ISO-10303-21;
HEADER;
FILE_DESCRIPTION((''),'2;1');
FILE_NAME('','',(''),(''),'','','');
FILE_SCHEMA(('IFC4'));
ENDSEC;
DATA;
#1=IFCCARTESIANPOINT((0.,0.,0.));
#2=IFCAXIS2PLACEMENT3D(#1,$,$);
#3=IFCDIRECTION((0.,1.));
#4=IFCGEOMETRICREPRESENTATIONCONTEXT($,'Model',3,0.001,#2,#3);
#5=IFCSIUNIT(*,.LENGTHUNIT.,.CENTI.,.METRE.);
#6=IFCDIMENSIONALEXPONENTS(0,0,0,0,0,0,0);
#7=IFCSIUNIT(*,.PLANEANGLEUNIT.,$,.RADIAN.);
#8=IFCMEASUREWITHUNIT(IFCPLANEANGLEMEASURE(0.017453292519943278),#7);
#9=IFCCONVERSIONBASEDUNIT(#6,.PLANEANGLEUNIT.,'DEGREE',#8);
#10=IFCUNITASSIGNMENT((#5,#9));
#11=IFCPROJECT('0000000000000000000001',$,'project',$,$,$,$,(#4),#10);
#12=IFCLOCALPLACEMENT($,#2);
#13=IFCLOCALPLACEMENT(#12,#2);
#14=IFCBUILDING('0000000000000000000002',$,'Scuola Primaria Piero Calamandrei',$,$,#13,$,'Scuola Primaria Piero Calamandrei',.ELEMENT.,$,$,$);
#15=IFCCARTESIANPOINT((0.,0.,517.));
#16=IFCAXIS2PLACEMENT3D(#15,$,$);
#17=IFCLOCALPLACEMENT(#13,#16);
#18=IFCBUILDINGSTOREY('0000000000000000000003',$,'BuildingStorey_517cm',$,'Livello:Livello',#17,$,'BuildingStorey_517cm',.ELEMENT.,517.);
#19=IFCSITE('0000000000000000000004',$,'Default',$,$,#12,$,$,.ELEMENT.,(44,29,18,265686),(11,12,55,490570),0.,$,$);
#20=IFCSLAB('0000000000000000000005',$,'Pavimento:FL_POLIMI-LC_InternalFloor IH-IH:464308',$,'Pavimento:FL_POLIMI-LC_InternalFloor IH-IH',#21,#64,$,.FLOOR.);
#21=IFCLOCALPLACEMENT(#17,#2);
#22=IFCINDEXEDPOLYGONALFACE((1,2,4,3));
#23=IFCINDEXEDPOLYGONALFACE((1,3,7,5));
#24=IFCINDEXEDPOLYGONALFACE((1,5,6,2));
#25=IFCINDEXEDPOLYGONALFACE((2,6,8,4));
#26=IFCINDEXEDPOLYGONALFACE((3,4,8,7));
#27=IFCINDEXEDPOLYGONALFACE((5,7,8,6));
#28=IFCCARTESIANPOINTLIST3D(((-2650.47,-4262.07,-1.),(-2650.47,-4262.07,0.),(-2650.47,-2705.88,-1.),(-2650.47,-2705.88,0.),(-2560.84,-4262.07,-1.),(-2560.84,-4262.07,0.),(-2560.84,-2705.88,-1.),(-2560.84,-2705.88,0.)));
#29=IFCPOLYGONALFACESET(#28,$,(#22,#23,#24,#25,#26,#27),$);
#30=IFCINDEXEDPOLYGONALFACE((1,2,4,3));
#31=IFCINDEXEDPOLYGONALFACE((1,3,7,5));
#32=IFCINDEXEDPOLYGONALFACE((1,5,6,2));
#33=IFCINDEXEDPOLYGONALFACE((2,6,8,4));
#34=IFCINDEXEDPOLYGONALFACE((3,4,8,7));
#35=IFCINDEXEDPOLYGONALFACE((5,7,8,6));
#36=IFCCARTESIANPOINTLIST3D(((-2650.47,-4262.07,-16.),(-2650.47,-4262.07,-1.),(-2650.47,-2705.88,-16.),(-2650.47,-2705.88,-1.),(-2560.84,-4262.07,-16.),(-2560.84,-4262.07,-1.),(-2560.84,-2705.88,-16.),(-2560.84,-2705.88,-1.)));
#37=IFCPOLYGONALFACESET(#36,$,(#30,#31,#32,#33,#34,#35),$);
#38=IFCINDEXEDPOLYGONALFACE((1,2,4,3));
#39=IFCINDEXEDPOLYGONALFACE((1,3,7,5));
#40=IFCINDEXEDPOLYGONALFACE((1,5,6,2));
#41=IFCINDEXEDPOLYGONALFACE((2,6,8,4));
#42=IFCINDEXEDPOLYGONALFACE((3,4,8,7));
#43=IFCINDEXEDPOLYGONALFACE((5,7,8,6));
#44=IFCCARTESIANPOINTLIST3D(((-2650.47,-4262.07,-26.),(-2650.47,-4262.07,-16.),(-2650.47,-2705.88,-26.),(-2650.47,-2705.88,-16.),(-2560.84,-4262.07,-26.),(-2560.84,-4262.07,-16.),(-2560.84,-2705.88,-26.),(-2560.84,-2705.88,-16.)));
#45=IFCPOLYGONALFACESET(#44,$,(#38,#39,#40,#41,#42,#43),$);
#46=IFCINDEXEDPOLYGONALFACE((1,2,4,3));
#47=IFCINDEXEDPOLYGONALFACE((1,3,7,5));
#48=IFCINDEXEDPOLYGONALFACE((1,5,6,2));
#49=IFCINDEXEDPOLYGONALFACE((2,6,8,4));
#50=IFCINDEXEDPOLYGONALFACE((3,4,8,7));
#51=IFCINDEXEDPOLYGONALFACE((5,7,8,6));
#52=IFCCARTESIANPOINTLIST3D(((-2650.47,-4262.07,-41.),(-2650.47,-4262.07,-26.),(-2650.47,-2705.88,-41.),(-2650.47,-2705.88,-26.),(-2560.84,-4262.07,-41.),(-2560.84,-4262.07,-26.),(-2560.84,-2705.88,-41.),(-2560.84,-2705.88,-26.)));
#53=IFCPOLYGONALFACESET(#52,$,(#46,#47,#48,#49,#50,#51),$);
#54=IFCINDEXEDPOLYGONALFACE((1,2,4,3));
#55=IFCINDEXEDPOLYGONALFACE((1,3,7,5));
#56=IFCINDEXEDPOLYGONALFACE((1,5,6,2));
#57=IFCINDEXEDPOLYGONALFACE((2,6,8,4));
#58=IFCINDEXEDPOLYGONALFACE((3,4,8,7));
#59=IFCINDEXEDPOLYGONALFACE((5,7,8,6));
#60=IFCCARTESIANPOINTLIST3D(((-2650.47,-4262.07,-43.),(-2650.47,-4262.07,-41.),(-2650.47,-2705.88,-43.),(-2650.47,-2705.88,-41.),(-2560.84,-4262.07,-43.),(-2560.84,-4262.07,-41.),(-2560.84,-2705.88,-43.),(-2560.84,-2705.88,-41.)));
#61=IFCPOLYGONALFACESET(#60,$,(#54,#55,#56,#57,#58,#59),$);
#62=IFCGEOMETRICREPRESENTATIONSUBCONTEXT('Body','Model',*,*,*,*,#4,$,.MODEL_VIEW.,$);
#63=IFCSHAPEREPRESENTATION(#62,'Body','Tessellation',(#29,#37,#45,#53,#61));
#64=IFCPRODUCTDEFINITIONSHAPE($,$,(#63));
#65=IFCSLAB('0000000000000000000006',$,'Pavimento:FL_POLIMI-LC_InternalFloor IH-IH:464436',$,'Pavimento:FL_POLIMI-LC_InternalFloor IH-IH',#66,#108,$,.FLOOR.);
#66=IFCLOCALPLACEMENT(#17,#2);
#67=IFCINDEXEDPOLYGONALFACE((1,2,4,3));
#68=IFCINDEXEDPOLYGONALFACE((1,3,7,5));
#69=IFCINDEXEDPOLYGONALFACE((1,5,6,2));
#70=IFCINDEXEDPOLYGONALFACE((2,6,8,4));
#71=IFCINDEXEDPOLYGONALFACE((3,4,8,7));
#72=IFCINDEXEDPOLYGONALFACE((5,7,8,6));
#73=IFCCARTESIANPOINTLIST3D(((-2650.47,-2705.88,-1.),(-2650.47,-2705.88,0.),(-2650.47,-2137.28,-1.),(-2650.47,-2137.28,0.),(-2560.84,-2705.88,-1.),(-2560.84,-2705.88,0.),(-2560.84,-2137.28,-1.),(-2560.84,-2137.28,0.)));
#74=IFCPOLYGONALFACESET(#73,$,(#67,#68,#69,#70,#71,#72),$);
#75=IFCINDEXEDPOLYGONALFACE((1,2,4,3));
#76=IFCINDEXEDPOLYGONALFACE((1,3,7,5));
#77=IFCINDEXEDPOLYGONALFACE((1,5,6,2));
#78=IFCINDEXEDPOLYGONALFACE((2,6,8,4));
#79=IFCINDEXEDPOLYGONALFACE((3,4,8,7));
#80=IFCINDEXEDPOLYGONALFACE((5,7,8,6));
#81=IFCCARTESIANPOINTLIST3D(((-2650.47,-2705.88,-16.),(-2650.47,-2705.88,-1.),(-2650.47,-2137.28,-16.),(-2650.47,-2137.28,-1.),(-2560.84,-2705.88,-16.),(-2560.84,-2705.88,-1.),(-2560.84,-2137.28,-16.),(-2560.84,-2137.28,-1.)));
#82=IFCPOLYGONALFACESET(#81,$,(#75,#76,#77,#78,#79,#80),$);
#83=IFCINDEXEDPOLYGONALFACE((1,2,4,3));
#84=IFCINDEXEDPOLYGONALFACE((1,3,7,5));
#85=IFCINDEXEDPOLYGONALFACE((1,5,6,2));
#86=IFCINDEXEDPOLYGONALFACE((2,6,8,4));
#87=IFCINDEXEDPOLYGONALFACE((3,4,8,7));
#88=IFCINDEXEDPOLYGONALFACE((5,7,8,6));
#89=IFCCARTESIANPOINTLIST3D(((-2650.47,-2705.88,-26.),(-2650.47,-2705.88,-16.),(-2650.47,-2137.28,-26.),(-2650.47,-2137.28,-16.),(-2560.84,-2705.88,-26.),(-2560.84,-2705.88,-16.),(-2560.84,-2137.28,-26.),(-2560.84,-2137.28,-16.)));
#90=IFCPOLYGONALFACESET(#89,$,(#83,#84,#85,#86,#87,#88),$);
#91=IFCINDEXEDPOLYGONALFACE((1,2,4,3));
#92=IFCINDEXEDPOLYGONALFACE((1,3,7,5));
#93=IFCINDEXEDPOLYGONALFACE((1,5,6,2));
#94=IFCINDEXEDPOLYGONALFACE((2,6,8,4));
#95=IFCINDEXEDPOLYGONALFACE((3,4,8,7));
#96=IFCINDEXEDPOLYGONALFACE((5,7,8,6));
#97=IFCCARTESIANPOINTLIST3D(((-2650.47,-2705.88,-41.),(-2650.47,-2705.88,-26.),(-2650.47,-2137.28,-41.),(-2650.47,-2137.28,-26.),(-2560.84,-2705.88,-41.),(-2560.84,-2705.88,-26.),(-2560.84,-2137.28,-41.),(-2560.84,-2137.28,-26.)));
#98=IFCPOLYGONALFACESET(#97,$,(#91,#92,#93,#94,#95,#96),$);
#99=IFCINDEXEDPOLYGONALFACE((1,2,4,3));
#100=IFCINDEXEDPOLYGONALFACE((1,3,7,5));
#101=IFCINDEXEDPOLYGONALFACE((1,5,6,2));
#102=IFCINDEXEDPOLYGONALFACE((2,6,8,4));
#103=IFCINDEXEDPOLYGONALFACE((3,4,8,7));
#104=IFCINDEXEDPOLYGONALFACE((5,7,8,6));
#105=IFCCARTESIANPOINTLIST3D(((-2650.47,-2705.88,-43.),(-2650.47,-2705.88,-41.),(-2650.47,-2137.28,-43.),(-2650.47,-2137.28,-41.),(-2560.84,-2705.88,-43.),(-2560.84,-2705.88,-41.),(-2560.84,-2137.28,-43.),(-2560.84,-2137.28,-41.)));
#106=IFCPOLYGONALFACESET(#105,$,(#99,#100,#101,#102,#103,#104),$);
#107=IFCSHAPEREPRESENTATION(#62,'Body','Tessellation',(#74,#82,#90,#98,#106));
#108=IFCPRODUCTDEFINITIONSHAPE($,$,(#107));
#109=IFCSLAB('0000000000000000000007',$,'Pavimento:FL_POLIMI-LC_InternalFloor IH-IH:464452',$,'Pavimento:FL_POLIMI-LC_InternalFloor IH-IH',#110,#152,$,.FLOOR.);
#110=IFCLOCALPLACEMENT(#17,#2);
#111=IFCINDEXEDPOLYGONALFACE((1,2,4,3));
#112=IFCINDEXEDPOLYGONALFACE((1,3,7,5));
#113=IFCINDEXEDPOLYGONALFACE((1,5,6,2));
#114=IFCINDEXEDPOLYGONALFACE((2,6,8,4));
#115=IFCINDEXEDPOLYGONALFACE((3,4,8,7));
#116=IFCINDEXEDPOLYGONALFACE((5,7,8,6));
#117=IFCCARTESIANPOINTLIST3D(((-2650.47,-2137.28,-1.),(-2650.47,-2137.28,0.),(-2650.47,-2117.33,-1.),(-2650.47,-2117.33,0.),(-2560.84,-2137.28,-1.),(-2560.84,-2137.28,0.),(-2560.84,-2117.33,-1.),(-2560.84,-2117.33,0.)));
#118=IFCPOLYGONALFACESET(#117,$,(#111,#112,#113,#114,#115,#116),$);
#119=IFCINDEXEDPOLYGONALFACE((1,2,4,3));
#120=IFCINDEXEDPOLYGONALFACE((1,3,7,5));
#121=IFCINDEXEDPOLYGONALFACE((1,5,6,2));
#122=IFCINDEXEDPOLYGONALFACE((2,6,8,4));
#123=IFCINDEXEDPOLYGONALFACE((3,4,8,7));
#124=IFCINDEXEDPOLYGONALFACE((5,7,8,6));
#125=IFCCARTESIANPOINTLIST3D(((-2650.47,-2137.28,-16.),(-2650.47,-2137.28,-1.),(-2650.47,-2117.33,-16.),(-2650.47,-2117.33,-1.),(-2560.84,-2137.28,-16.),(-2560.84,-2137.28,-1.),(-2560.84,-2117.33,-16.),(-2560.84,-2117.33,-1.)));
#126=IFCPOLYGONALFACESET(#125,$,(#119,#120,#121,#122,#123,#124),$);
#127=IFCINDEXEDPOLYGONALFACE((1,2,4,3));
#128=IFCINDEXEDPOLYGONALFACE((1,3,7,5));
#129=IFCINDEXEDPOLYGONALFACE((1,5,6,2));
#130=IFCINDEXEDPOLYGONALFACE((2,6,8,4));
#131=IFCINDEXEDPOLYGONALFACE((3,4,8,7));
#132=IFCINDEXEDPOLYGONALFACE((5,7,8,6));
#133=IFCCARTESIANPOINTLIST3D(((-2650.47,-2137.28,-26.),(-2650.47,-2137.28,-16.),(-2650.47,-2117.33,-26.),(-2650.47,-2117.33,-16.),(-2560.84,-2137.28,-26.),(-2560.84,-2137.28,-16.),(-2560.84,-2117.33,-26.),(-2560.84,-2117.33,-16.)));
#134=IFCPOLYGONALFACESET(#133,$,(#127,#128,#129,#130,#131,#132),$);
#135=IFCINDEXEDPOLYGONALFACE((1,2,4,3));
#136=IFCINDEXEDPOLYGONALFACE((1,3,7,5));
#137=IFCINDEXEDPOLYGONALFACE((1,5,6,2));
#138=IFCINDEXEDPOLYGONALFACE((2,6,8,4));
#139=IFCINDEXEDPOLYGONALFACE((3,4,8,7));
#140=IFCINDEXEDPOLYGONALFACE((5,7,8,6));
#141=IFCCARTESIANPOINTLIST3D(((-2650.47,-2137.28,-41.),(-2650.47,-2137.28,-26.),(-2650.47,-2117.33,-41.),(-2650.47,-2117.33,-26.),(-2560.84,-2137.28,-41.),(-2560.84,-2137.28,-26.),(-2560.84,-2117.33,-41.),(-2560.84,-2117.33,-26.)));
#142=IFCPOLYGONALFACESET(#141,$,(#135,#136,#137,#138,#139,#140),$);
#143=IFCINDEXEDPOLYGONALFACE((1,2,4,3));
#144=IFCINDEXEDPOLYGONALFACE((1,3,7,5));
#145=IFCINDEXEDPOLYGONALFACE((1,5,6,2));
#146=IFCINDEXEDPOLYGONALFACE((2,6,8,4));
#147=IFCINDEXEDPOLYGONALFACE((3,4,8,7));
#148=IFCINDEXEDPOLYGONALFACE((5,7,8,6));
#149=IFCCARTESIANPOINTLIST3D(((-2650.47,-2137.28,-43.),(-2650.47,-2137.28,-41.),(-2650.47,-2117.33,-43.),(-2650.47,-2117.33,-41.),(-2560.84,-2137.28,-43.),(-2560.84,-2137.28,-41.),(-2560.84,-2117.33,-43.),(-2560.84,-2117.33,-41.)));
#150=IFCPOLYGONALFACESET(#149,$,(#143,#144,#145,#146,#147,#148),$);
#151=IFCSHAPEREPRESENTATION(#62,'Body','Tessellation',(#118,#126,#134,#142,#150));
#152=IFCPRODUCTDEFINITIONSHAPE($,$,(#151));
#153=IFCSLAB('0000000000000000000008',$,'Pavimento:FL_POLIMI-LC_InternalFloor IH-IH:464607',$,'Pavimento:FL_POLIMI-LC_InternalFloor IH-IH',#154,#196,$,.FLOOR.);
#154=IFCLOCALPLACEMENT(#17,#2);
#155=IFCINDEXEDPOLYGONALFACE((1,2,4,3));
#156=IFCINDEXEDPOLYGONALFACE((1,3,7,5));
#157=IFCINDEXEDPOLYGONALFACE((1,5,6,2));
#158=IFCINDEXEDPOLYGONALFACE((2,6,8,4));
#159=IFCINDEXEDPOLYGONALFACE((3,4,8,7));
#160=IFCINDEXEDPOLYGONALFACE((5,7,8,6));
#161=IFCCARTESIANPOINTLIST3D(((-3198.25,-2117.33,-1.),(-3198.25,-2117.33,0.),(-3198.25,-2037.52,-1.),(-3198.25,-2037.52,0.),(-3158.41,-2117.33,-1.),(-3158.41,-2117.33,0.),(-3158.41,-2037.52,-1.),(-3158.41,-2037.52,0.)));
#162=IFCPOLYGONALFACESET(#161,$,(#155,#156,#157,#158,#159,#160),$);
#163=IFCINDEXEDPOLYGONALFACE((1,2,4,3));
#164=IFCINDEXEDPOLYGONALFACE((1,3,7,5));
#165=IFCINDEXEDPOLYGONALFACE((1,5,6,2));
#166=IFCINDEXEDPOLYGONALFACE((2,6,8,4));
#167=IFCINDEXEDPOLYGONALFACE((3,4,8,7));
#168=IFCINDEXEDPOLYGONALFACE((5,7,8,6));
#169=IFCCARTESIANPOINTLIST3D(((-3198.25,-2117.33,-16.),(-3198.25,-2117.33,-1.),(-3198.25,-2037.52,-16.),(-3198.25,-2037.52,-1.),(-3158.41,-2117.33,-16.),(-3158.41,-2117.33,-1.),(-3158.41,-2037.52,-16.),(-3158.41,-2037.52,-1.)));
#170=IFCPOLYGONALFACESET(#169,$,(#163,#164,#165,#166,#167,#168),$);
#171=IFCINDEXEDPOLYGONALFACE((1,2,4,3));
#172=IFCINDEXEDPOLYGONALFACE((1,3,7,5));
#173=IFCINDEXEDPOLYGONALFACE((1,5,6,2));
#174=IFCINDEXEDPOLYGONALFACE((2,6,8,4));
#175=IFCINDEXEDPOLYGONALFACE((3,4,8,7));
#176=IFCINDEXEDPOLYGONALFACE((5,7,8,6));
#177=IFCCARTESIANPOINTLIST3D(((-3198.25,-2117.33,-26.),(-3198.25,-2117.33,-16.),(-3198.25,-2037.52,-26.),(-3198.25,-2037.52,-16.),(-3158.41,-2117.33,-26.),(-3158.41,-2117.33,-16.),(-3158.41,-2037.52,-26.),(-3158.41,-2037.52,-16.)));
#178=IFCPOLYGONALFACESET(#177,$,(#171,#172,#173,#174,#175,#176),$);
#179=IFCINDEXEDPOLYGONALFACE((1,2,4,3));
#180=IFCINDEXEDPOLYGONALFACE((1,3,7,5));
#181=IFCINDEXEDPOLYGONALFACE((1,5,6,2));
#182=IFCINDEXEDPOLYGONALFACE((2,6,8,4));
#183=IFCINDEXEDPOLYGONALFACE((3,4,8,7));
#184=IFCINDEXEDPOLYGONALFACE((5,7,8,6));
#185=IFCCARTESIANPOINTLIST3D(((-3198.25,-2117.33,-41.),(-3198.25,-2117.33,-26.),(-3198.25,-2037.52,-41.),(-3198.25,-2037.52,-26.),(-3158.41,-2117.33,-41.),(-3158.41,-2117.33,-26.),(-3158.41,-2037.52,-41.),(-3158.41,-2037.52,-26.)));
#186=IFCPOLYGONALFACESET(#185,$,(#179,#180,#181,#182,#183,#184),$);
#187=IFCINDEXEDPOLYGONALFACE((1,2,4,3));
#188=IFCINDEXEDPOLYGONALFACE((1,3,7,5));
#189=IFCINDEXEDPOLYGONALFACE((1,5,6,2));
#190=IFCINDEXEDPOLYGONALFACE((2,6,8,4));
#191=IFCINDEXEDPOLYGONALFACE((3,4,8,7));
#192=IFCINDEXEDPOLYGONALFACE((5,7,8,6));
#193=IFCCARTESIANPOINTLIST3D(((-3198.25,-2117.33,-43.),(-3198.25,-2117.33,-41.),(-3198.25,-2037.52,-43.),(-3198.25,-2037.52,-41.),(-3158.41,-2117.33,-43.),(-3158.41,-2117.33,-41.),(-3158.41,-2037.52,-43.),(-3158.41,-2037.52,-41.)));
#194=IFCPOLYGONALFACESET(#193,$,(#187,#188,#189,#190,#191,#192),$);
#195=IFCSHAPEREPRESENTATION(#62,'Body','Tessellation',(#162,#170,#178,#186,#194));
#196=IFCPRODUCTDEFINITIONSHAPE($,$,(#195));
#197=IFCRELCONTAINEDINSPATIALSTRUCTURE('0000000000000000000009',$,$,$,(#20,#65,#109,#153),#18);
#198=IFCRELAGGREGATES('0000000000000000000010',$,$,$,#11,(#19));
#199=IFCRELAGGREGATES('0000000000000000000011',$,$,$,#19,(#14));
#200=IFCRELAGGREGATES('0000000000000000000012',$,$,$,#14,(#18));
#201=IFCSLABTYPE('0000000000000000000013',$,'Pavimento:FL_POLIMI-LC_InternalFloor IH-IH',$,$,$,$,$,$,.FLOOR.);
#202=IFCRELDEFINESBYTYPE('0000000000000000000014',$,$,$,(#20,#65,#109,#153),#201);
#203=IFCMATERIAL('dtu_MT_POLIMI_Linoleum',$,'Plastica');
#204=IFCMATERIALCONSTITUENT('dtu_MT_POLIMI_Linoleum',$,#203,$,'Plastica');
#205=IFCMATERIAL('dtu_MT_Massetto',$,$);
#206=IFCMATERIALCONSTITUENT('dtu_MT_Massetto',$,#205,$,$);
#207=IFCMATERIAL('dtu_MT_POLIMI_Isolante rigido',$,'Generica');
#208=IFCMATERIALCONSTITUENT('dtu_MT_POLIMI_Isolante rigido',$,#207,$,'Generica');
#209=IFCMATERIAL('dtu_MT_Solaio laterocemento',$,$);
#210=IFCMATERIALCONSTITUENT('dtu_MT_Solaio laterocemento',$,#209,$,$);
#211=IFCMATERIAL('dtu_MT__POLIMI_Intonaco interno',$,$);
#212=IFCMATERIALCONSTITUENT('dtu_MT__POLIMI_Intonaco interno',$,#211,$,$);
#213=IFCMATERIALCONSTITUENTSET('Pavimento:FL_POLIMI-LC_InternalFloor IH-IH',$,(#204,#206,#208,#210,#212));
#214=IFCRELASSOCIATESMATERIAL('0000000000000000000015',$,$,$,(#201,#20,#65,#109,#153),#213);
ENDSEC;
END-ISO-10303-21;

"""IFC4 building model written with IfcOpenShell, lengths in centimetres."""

from ifc_helpers import new_model, entity, si_unit, converted_unit, direction, frame, origin, place, context, subcontext, project, spatial, indexed_curve, outline, extrude, material, constituent, constituent_set, type_object, element, save


model = new_model("IFC4")

# Units and contexts
model_context = context("Model", 3, precision=0.001, world=origin(), true_north=direction((0.0, 1.0)))
body_context = subcontext(model_context, "Body", "Model", "MODEL_VIEW")
ifc_project = project(units=[si_unit("LENGTHUNIT", "METRE", prefix="CENTI"), converted_unit("PLANEANGLEUNIT", "DEGREE", entity("IfcPlaneAngleMeasure", 0.017453292519943278), si_unit("PLANEANGLEUNIT", "RADIAN"), dimensions=[0, 0, 0, 0, 0, 0, 0])], contexts=[model_context])

# Site, building, storey
site_placement = place(None, origin())
site = spatial("IfcSite", under=ifc_project, at=site_placement, Name="Default", CompositionType="ELEMENT", RefLatitude=(44, 29, 18, 265686), RefLongitude=(11, 12, 55, 490570), RefElevation=0.0)
building_placement = place(site_placement, origin())
building = spatial("IfcBuilding", under=site, at=building_placement, Name="Scuola Primaria Piero Calamandrei", LongName="Scuola Primaria Piero Calamandrei", CompositionType="ELEMENT")
storey_placement = place(building_placement, frame((0.0, 0.0, 517.0)))
storey = spatial("IfcBuildingStorey", under=building, at=storey_placement, Name="BuildingStorey_517cm", ObjectType="Livello:Livello", LongName="BuildingStorey_517cm", CompositionType="ELEMENT", Elevation=517.0)

# Slabs
ifc_material_1 = material(Name="dtu_MT_POLIMI_Linoleum", Category="Plastica")
ifc_material_2 = material(Name="dtu_MT_Massetto")
ifc_material_3 = material(Name="dtu_MT_POLIMI_Isolante rigido", Category="Generica")
ifc_material_4 = material(Name="dtu_MT_Solaio laterocemento")
ifc_material_5 = material(Name="dtu_MT__POLIMI_Intonaco interno")
ifc_constituent_1 = constituent(ifc_material_1, Name="dtu_MT_POLIMI_Linoleum", Category="Plastica")
ifc_constituent_2 = constituent(ifc_material_2, Name="dtu_MT_Massetto")
ifc_constituent_3 = constituent(ifc_material_3, Name="dtu_MT_POLIMI_Isolante rigido", Category="Generica")
ifc_constituent_4 = constituent(ifc_material_4, Name="dtu_MT_Solaio laterocemento")
ifc_constituent_5 = constituent(ifc_material_5, Name="dtu_MT__POLIMI_Intonaco interno")
ifc_constituent_set_1 = constituent_set(constituents=[ifc_constituent_1, ifc_constituent_2, ifc_constituent_3, ifc_constituent_4, ifc_constituent_5], Name="Pavimento:FL_POLIMI-LC_InternalFloor IH-IH")
slab_type_1 = type_object("IfcSlabType", Name="Pavimento:FL_POLIMI-LC_InternalFloor IH-IH", PredefinedType="FLOOR", material=ifc_constituent_set_1)
slab_1_placement = place(storey_placement, origin())
element("IfcSlab", 1, at=slab_1_placement, inside=storey, type_object=slab_type_1, material=ifc_constituent_set_1, Name="Pavimento:FL_POLIMI-LC_InternalFloor IH-IH:464308", ObjectType="Pavimento:FL_POLIMI-LC_InternalFloor IH-IH", PredefinedType="FLOOR", context=body_context, shape_type="SweptSolid", body=[
    extrude(outline(indexed_curve([(-44.82, -778.09), (44.82, -778.09), (44.82, 778.09), (-44.82, 778.09), (-44.82, -778.09)], self_intersect=False)), frame((-2605.65, -3483.98, -1.0)), (0.0, 0.0, 1.0), 1.0),
    extrude(outline(indexed_curve([(-44.82, -778.09), (44.82, -778.09), (44.82, 778.09), (-44.82, 778.09), (-44.82, -778.09)], self_intersect=False)), frame((-2605.65, -3483.98, -16.0)), (0.0, 0.0, 1.0), 15.0),
    extrude(outline(indexed_curve([(-44.82, -778.09), (44.82, -778.09), (44.82, 778.09), (-44.82, 778.09), (-44.82, -778.09)], self_intersect=False)), frame((-2605.65, -3483.98, -26.0)), (0.0, 0.0, 1.0), 10.0),
    extrude(outline(indexed_curve([(-44.82, -778.09), (44.82, -778.09), (44.82, 778.09), (-44.82, 778.09), (-44.82, -778.09)], self_intersect=False)), frame((-2605.65, -3483.98, -41.0)), (0.0, 0.0, 1.0), 15.0),
    extrude(outline(indexed_curve([(-44.82, -778.09), (44.82, -778.09), (44.82, 778.09), (-44.82, 778.09), (-44.82, -778.09)], self_intersect=False)), frame((-2605.65, -3483.98, -43.0)), (0.0, 0.0, 1.0), 2.0),
])
slab_2_placement = place(storey_placement, origin())
element("IfcSlab", 2, at=slab_2_placement, inside=storey, type_object=slab_type_1, material=ifc_constituent_set_1, Name="Pavimento:FL_POLIMI-LC_InternalFloor IH-IH:464436", ObjectType="Pavimento:FL_POLIMI-LC_InternalFloor IH-IH", PredefinedType="FLOOR", context=body_context, shape_type="SweptSolid", body=[
    extrude(outline(indexed_curve([(-284.3, -44.82), (284.3, -44.82), (284.3, 44.82), (-284.3, 44.82), (-284.3, -44.82)], self_intersect=False)), frame((-2605.65, -2421.58, -1.0), z_axis=(0.0, 0.0, 1.0), x_axis=(0.0, 1.0, 0.0)), (0.0, 0.0, 1.0), 1.0),
    extrude(outline(indexed_curve([(-284.3, -44.82), (284.3, -44.82), (284.3, 44.82), (-284.3, 44.82), (-284.3, -44.82)], self_intersect=False)), frame((-2605.65, -2421.58, -16.0), z_axis=(0.0, 0.0, 1.0), x_axis=(0.0, 1.0, 0.0)), (0.0, 0.0, 1.0), 15.0),
    extrude(outline(indexed_curve([(-284.3, -44.82), (284.3, -44.82), (284.3, 44.82), (-284.3, 44.82), (-284.3, -44.82)], self_intersect=False)), frame((-2605.65, -2421.58, -26.0), z_axis=(0.0, 0.0, 1.0), x_axis=(0.0, 1.0, 0.0)), (0.0, 0.0, 1.0), 10.0),
    extrude(outline(indexed_curve([(-284.3, -44.82), (284.3, -44.82), (284.3, 44.82), (-284.3, 44.82), (-284.3, -44.82)], self_intersect=False)), frame((-2605.65, -2421.58, -41.0), z_axis=(0.0, 0.0, 1.0), x_axis=(0.0, 1.0, 0.0)), (0.0, 0.0, 1.0), 15.0),
    extrude(outline(indexed_curve([(-284.3, -44.82), (284.3, -44.82), (284.3, 44.82), (-284.3, 44.82), (-284.3, -44.82)], self_intersect=False)), frame((-2605.65, -2421.58, -43.0), z_axis=(0.0, 0.0, 1.0), x_axis=(0.0, 1.0, 0.0)), (0.0, 0.0, 1.0), 2.0),
])
slab_3_placement = place(storey_placement, origin())
element("IfcSlab", 3, at=slab_3_placement, inside=storey, type_object=slab_type_1, material=ifc_constituent_set_1, Name="Pavimento:FL_POLIMI-LC_InternalFloor IH-IH:464452", ObjectType="Pavimento:FL_POLIMI-LC_InternalFloor IH-IH", PredefinedType="FLOOR", context=body_context, shape_type="SweptSolid", body=[
    extrude(outline(indexed_curve([(-44.82, -9.98), (44.82, -9.98), (44.82, 9.98), (-44.82, 9.98), (-44.82, -9.98)], self_intersect=False)), frame((-2605.65, -2127.3, -1.0)), (0.0, 0.0, 1.0), 1.0),
    extrude(outline(indexed_curve([(-44.82, -9.98), (44.82, -9.98), (44.82, 9.98), (-44.82, 9.98), (-44.82, -9.98)], self_intersect=False)), frame((-2605.65, -2127.3, -16.0)), (0.0, 0.0, 1.0), 15.0),
    extrude(outline(indexed_curve([(-44.82, -9.98), (44.82, -9.98), (44.82, 9.98), (-44.82, 9.98), (-44.82, -9.98)], self_intersect=False)), frame((-2605.65, -2127.3, -26.0)), (0.0, 0.0, 1.0), 10.0),
    extrude(outline(indexed_curve([(-44.82, -9.98), (44.82, -9.98), (44.82, 9.98), (-44.82, 9.98), (-44.82, -9.98)], self_intersect=False)), frame((-2605.65, -2127.3, -41.0)), (0.0, 0.0, 1.0), 15.0),
    extrude(outline(indexed_curve([(-44.82, -9.98), (44.82, -9.98), (44.82, 9.98), (-44.82, 9.98), (-44.82, -9.98)], self_intersect=False)), frame((-2605.65, -2127.3, -43.0)), (0.0, 0.0, 1.0), 2.0),
])
slab_4_placement = place(storey_placement, origin())
element("IfcSlab", 4, at=slab_4_placement, inside=storey, type_object=slab_type_1, material=ifc_constituent_set_1, Name="Pavimento:FL_POLIMI-LC_InternalFloor IH-IH:464607", ObjectType="Pavimento:FL_POLIMI-LC_InternalFloor IH-IH", PredefinedType="FLOOR", context=body_context, shape_type="SweptSolid", body=[
    extrude(outline(indexed_curve([(-39.9, -19.92), (39.9, -19.92), (39.9, 19.92), (-39.9, 19.92), (-39.9, -19.92)], self_intersect=False)), frame((-3178.33, -2077.42, -1.0), z_axis=(0.0, 0.0, 1.0), x_axis=(0.0, 1.0, 0.0)), (0.0, 0.0, 1.0), 1.0),
    extrude(outline(indexed_curve([(-39.9, -19.92), (39.9, -19.92), (39.9, 19.92), (-39.9, 19.92), (-39.9, -19.92)], self_intersect=False)), frame((-3178.33, -2077.42, -16.0), z_axis=(0.0, 0.0, 1.0), x_axis=(0.0, 1.0, 0.0)), (0.0, 0.0, 1.0), 15.0),
    extrude(outline(indexed_curve([(-39.9, -19.92), (39.9, -19.92), (39.9, 19.92), (-39.9, 19.92), (-39.9, -19.92)], self_intersect=False)), frame((-3178.33, -2077.42, -26.0), z_axis=(0.0, 0.0, 1.0), x_axis=(0.0, 1.0, 0.0)), (0.0, 0.0, 1.0), 10.0),
    extrude(outline(indexed_curve([(-39.9, -19.92), (39.9, -19.92), (39.9, 19.92), (-39.9, 19.92), (-39.9, -19.92)], self_intersect=False)), frame((-3178.33, -2077.42, -41.0), z_axis=(0.0, 0.0, 1.0), x_axis=(0.0, 1.0, 0.0)), (0.0, 0.0, 1.0), 15.0),
    extrude(outline(indexed_curve([(-39.9, -19.92), (39.9, -19.92), (39.9, 19.92), (-39.9, 19.92), (-39.9, -19.92)], self_intersect=False)), frame((-3178.33, -2077.42, -43.0), z_axis=(0.0, 0.0, 1.0), x_axis=(0.0, 1.0, 0.0)), (0.0, 0.0, 1.0), 2.0),
])

save(model, "model.ifc")
